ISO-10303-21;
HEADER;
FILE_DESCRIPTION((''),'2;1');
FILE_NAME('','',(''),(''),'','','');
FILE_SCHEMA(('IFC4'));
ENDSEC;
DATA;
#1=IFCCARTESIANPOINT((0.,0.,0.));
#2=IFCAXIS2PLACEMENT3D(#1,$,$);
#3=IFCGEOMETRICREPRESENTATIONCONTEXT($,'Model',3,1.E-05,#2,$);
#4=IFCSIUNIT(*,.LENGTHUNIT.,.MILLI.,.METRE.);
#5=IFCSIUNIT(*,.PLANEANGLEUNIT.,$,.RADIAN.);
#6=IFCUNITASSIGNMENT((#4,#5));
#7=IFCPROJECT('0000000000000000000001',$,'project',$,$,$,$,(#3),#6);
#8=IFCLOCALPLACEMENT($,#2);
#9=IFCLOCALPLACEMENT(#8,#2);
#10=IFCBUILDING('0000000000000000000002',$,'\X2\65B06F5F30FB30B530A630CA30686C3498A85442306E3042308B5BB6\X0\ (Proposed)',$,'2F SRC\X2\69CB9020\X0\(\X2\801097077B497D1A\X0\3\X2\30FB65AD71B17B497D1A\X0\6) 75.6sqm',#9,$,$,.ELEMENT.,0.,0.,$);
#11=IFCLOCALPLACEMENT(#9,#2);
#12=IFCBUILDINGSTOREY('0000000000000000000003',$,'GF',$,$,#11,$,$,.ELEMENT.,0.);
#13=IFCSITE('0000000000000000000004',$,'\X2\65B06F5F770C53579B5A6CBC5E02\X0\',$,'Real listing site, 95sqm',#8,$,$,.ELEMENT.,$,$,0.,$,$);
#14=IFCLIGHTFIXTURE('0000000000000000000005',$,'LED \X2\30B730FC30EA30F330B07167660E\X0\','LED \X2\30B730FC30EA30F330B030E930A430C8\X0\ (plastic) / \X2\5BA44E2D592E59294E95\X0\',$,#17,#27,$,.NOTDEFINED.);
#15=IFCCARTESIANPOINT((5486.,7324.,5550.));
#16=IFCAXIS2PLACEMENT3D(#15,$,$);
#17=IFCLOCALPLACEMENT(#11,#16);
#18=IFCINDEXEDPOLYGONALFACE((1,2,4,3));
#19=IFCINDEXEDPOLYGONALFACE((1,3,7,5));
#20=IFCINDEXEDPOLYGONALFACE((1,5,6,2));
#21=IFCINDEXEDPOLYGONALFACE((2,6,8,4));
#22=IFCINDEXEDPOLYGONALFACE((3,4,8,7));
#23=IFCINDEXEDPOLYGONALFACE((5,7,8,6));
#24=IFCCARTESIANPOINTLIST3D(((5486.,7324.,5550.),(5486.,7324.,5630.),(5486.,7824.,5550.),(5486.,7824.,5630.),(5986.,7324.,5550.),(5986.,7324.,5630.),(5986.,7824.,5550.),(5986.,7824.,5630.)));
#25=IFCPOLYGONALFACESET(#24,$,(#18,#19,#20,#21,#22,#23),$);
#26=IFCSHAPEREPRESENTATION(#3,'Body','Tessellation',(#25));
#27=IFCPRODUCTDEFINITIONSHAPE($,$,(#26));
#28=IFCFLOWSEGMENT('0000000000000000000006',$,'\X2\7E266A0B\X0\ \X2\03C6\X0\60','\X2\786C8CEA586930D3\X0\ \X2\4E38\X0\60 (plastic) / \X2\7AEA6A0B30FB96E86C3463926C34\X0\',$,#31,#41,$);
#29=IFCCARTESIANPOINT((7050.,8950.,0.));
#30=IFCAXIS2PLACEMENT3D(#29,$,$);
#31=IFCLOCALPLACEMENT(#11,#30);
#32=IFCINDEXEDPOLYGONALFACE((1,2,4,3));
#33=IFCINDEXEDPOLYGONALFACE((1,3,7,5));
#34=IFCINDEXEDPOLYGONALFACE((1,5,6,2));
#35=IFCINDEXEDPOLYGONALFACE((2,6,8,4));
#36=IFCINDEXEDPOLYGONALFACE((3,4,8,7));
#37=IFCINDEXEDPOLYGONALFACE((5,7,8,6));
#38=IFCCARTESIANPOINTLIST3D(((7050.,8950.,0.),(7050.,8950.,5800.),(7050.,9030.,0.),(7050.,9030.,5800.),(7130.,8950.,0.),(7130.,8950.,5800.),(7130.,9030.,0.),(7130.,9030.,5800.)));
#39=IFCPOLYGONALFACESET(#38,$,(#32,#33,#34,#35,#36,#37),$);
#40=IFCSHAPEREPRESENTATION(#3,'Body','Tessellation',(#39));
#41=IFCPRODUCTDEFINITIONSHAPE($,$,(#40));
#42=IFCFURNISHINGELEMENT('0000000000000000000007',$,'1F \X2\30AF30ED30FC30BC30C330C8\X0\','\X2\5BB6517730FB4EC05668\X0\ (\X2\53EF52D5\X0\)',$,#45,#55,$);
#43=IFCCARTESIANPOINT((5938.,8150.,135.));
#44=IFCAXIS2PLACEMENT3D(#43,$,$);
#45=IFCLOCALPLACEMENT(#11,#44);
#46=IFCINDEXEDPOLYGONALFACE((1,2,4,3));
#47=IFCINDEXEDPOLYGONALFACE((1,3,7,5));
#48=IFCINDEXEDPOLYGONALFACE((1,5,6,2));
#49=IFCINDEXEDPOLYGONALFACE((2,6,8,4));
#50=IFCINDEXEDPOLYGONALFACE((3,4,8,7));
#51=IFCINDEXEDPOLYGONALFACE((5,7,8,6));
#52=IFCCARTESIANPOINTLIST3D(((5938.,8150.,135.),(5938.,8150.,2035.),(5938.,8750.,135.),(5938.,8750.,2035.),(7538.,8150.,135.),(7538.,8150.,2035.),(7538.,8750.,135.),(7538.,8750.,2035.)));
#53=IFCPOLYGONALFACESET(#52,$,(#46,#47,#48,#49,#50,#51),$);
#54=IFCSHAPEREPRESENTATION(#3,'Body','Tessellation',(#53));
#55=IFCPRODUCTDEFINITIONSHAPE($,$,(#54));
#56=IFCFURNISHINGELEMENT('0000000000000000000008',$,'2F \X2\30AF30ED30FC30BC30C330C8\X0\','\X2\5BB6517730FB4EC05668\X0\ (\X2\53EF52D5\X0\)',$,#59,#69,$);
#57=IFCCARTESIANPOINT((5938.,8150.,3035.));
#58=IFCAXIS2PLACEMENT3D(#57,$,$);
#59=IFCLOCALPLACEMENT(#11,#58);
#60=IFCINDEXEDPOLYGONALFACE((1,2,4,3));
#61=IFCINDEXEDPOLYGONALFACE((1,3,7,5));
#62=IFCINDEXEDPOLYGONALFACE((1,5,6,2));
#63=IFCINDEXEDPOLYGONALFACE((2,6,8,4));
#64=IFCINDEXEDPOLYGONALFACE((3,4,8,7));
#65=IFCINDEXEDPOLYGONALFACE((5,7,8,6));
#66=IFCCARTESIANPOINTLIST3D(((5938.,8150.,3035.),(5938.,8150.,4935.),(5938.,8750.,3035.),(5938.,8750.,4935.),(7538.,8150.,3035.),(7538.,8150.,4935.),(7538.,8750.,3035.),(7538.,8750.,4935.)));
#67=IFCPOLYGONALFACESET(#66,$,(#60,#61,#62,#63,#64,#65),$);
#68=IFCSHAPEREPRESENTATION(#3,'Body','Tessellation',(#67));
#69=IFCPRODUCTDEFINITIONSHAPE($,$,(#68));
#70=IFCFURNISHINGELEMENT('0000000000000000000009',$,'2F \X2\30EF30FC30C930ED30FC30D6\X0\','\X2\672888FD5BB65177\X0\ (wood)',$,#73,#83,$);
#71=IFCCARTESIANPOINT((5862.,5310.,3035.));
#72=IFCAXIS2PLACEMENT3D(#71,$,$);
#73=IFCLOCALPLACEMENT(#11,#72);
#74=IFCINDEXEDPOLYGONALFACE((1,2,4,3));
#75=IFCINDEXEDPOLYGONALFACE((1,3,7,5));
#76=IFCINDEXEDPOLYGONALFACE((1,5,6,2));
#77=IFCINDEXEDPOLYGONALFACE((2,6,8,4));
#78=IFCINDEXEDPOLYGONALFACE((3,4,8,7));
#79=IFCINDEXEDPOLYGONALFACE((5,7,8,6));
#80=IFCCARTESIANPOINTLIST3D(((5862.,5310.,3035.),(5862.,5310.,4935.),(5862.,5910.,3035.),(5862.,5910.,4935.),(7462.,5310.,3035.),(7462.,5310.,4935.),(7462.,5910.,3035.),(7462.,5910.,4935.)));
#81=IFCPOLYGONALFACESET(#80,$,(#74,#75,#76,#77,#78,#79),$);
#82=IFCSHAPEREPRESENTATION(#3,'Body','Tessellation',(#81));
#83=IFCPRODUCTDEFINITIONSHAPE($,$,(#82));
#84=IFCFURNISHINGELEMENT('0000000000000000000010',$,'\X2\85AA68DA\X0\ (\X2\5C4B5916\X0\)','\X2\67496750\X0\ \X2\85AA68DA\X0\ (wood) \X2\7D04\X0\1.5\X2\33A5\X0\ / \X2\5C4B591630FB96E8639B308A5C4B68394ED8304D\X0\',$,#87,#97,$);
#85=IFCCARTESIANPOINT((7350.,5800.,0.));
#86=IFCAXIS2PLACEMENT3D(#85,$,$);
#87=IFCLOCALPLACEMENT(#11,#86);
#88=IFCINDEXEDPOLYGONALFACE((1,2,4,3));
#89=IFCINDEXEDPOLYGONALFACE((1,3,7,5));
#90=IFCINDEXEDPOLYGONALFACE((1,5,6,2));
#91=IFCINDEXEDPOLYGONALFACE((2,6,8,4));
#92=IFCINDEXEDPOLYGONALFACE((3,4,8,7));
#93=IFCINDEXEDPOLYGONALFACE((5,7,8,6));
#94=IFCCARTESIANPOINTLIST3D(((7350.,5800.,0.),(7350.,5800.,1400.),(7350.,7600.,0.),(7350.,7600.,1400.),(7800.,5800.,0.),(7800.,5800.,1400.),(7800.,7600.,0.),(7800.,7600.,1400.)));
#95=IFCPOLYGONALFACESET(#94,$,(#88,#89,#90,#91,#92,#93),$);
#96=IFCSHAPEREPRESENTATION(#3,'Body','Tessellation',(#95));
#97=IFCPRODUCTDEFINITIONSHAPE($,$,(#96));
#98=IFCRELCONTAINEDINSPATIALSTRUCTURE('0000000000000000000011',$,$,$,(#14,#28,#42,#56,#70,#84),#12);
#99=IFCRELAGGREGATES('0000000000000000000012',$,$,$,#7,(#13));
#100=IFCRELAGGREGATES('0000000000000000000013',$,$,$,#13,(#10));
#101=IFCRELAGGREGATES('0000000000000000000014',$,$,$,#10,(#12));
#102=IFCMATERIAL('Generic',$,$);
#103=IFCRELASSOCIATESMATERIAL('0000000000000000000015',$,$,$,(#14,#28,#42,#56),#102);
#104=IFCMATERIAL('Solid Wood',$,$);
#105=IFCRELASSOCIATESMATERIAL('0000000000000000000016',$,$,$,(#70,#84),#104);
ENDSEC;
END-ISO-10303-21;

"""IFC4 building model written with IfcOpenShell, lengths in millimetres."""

from ifc_helpers import new_model, si_unit, frame, frame_2d, origin, place, context, project, spatial, rectangle, extrude, material, element, save


model = new_model("IFC4")

# Units and contexts
model_context = context("Model", 3, precision=1e-05, world=origin())
ifc_project = project(units=[si_unit("LENGTHUNIT", "METRE", prefix="MILLI"), si_unit("PLANEANGLEUNIT", "RADIAN")], contexts=[model_context])

# Site, building, storey
site_placement = place(None, origin())
site = spatial("IfcSite", under=ifc_project, at=site_placement, Name="新潟県南魚沼市", ObjectType="Real listing site, 95sqm", CompositionType="ELEMENT", RefElevation=0.0)
building_placement = place(site_placement, origin())
building = spatial("IfcBuilding", under=site, at=building_placement, Name="新潟・サウナと水風呂のある家 (Proposed)", ObjectType="2F SRC構造(耐震等級3・断熱等級6) 75.6sqm", CompositionType="ELEMENT", ElevationOfRefHeight=0.0, ElevationOfTerrain=0.0)
storey_placement = place(building_placement, origin())
storey = spatial("IfcBuildingStorey", under=building, at=storey_placement, Name="GF", CompositionType="ELEMENT", Elevation=0.0)

# Shared definitions
ifc_material_1 = material(Name="Solid Wood")

# Shared definitions
ifc_material_2 = material(Name="Generic")

# Light fixture
light_fixture_1_placement = place(storey_placement, frame((5486.0, 7324.0, 5550.0)))
element("IfcLightFixture", 1, at=light_fixture_1_placement, inside=storey, material=ifc_material_2, Name="LED シーリング照明", Description="LED シーリングライト (plastic) / 室中央天井", PredefinedType="NOTDEFINED", context=model_context, shape_type="SweptSolid", body=[
    extrude(rectangle(XDim=500.0, YDim=500.0, at=frame_2d((250.0, 250.0))), frame((5486.0, 7324.0, 5550.0)), (0.0, 0.0, 1.0), 80.0),
])

# Flow segment
flow_segment_placement = place(storey_placement, frame((7050.0, 8950.0, 0.0)))
element("IfcFlowSegment", 2, at=flow_segment_placement, inside=storey, material=ifc_material_2, Name="縦樋 φ60", Description="硬質塩ビ 丸60 (plastic) / 竪樋・雨水排水", context=model_context, shape_type="SweptSolid", body=[
    extrude(rectangle(XDim=80.0, YDim=80.0, at=frame_2d((40.0, 40.0))), frame((7050.0, 8950.0, 0.0)), (0.0, 0.0, 1.0), 5800.0),
])

# Furnishing elements
furnishing_1_placement = place(storey_placement, frame((5938.0, 8150.0, 135.0)))
element("IfcFurnishingElement", 3, at=furnishing_1_placement, inside=storey, material=ifc_material_2, Name="1F クローゼット", Description="家具・什器 (可動)", context=model_context, shape_type="SweptSolid", body=[
    extrude(rectangle(XDim=1600.0, YDim=600.0, at=frame_2d((800.0, 300.0))), frame((5938.0, 8150.0, 135.0)), (0.0, 0.0, 1.0), 1900.0),
])
furnishing_2_placement = place(storey_placement, frame((5938.0, 8150.0, 3035.0)))
element("IfcFurnishingElement", 4, at=furnishing_2_placement, inside=storey, material=ifc_material_2, Name="2F クローゼット", Description="家具・什器 (可動)", context=model_context, shape_type="SweptSolid", body=[
    extrude(rectangle(XDim=1600.0, YDim=600.0, at=frame_2d((800.0, 300.0))), frame((5938.0, 8150.0, 3035.0)), (0.0, 0.0, 1.0), 1900.0),
])
furnishing_3_placement = place(storey_placement, frame((5862.0, 5310.0, 3035.0)))
element("IfcFurnishingElement", 5, at=furnishing_3_placement, inside=storey, material=ifc_material_1, Name="2F ワードローブ", Description="木製家具 (wood)", context=model_context, shape_type="SweptSolid", body=[
    extrude(rectangle(XDim=1600.0, YDim=600.0, at=frame_2d((800.0, 300.0))), frame((5862.0, 5310.0, 3035.0)), (0.0, 0.0, 1.0), 1900.0),
])
furnishing_4_placement = place(storey_placement, frame((7350.0, 5800.0, 0.0)))
element("IfcFurnishingElement", 6, at=furnishing_4_placement, inside=storey, material=ifc_material_1, Name="薪棚 (屋外)", Description="杉材 薪棚 (wood) 約1.5㎥ / 屋外・雨掛り屋根付き", context=model_context, shape_type="SweptSolid", body=[
    extrude(rectangle(XDim=450.0, YDim=1800.0, at=frame_2d((225.0, 900.0))), frame((7350.0, 5800.0, 0.0)), (0.0, 0.0, 1.0), 1400.0),
])

save(model, "model.ifc")
